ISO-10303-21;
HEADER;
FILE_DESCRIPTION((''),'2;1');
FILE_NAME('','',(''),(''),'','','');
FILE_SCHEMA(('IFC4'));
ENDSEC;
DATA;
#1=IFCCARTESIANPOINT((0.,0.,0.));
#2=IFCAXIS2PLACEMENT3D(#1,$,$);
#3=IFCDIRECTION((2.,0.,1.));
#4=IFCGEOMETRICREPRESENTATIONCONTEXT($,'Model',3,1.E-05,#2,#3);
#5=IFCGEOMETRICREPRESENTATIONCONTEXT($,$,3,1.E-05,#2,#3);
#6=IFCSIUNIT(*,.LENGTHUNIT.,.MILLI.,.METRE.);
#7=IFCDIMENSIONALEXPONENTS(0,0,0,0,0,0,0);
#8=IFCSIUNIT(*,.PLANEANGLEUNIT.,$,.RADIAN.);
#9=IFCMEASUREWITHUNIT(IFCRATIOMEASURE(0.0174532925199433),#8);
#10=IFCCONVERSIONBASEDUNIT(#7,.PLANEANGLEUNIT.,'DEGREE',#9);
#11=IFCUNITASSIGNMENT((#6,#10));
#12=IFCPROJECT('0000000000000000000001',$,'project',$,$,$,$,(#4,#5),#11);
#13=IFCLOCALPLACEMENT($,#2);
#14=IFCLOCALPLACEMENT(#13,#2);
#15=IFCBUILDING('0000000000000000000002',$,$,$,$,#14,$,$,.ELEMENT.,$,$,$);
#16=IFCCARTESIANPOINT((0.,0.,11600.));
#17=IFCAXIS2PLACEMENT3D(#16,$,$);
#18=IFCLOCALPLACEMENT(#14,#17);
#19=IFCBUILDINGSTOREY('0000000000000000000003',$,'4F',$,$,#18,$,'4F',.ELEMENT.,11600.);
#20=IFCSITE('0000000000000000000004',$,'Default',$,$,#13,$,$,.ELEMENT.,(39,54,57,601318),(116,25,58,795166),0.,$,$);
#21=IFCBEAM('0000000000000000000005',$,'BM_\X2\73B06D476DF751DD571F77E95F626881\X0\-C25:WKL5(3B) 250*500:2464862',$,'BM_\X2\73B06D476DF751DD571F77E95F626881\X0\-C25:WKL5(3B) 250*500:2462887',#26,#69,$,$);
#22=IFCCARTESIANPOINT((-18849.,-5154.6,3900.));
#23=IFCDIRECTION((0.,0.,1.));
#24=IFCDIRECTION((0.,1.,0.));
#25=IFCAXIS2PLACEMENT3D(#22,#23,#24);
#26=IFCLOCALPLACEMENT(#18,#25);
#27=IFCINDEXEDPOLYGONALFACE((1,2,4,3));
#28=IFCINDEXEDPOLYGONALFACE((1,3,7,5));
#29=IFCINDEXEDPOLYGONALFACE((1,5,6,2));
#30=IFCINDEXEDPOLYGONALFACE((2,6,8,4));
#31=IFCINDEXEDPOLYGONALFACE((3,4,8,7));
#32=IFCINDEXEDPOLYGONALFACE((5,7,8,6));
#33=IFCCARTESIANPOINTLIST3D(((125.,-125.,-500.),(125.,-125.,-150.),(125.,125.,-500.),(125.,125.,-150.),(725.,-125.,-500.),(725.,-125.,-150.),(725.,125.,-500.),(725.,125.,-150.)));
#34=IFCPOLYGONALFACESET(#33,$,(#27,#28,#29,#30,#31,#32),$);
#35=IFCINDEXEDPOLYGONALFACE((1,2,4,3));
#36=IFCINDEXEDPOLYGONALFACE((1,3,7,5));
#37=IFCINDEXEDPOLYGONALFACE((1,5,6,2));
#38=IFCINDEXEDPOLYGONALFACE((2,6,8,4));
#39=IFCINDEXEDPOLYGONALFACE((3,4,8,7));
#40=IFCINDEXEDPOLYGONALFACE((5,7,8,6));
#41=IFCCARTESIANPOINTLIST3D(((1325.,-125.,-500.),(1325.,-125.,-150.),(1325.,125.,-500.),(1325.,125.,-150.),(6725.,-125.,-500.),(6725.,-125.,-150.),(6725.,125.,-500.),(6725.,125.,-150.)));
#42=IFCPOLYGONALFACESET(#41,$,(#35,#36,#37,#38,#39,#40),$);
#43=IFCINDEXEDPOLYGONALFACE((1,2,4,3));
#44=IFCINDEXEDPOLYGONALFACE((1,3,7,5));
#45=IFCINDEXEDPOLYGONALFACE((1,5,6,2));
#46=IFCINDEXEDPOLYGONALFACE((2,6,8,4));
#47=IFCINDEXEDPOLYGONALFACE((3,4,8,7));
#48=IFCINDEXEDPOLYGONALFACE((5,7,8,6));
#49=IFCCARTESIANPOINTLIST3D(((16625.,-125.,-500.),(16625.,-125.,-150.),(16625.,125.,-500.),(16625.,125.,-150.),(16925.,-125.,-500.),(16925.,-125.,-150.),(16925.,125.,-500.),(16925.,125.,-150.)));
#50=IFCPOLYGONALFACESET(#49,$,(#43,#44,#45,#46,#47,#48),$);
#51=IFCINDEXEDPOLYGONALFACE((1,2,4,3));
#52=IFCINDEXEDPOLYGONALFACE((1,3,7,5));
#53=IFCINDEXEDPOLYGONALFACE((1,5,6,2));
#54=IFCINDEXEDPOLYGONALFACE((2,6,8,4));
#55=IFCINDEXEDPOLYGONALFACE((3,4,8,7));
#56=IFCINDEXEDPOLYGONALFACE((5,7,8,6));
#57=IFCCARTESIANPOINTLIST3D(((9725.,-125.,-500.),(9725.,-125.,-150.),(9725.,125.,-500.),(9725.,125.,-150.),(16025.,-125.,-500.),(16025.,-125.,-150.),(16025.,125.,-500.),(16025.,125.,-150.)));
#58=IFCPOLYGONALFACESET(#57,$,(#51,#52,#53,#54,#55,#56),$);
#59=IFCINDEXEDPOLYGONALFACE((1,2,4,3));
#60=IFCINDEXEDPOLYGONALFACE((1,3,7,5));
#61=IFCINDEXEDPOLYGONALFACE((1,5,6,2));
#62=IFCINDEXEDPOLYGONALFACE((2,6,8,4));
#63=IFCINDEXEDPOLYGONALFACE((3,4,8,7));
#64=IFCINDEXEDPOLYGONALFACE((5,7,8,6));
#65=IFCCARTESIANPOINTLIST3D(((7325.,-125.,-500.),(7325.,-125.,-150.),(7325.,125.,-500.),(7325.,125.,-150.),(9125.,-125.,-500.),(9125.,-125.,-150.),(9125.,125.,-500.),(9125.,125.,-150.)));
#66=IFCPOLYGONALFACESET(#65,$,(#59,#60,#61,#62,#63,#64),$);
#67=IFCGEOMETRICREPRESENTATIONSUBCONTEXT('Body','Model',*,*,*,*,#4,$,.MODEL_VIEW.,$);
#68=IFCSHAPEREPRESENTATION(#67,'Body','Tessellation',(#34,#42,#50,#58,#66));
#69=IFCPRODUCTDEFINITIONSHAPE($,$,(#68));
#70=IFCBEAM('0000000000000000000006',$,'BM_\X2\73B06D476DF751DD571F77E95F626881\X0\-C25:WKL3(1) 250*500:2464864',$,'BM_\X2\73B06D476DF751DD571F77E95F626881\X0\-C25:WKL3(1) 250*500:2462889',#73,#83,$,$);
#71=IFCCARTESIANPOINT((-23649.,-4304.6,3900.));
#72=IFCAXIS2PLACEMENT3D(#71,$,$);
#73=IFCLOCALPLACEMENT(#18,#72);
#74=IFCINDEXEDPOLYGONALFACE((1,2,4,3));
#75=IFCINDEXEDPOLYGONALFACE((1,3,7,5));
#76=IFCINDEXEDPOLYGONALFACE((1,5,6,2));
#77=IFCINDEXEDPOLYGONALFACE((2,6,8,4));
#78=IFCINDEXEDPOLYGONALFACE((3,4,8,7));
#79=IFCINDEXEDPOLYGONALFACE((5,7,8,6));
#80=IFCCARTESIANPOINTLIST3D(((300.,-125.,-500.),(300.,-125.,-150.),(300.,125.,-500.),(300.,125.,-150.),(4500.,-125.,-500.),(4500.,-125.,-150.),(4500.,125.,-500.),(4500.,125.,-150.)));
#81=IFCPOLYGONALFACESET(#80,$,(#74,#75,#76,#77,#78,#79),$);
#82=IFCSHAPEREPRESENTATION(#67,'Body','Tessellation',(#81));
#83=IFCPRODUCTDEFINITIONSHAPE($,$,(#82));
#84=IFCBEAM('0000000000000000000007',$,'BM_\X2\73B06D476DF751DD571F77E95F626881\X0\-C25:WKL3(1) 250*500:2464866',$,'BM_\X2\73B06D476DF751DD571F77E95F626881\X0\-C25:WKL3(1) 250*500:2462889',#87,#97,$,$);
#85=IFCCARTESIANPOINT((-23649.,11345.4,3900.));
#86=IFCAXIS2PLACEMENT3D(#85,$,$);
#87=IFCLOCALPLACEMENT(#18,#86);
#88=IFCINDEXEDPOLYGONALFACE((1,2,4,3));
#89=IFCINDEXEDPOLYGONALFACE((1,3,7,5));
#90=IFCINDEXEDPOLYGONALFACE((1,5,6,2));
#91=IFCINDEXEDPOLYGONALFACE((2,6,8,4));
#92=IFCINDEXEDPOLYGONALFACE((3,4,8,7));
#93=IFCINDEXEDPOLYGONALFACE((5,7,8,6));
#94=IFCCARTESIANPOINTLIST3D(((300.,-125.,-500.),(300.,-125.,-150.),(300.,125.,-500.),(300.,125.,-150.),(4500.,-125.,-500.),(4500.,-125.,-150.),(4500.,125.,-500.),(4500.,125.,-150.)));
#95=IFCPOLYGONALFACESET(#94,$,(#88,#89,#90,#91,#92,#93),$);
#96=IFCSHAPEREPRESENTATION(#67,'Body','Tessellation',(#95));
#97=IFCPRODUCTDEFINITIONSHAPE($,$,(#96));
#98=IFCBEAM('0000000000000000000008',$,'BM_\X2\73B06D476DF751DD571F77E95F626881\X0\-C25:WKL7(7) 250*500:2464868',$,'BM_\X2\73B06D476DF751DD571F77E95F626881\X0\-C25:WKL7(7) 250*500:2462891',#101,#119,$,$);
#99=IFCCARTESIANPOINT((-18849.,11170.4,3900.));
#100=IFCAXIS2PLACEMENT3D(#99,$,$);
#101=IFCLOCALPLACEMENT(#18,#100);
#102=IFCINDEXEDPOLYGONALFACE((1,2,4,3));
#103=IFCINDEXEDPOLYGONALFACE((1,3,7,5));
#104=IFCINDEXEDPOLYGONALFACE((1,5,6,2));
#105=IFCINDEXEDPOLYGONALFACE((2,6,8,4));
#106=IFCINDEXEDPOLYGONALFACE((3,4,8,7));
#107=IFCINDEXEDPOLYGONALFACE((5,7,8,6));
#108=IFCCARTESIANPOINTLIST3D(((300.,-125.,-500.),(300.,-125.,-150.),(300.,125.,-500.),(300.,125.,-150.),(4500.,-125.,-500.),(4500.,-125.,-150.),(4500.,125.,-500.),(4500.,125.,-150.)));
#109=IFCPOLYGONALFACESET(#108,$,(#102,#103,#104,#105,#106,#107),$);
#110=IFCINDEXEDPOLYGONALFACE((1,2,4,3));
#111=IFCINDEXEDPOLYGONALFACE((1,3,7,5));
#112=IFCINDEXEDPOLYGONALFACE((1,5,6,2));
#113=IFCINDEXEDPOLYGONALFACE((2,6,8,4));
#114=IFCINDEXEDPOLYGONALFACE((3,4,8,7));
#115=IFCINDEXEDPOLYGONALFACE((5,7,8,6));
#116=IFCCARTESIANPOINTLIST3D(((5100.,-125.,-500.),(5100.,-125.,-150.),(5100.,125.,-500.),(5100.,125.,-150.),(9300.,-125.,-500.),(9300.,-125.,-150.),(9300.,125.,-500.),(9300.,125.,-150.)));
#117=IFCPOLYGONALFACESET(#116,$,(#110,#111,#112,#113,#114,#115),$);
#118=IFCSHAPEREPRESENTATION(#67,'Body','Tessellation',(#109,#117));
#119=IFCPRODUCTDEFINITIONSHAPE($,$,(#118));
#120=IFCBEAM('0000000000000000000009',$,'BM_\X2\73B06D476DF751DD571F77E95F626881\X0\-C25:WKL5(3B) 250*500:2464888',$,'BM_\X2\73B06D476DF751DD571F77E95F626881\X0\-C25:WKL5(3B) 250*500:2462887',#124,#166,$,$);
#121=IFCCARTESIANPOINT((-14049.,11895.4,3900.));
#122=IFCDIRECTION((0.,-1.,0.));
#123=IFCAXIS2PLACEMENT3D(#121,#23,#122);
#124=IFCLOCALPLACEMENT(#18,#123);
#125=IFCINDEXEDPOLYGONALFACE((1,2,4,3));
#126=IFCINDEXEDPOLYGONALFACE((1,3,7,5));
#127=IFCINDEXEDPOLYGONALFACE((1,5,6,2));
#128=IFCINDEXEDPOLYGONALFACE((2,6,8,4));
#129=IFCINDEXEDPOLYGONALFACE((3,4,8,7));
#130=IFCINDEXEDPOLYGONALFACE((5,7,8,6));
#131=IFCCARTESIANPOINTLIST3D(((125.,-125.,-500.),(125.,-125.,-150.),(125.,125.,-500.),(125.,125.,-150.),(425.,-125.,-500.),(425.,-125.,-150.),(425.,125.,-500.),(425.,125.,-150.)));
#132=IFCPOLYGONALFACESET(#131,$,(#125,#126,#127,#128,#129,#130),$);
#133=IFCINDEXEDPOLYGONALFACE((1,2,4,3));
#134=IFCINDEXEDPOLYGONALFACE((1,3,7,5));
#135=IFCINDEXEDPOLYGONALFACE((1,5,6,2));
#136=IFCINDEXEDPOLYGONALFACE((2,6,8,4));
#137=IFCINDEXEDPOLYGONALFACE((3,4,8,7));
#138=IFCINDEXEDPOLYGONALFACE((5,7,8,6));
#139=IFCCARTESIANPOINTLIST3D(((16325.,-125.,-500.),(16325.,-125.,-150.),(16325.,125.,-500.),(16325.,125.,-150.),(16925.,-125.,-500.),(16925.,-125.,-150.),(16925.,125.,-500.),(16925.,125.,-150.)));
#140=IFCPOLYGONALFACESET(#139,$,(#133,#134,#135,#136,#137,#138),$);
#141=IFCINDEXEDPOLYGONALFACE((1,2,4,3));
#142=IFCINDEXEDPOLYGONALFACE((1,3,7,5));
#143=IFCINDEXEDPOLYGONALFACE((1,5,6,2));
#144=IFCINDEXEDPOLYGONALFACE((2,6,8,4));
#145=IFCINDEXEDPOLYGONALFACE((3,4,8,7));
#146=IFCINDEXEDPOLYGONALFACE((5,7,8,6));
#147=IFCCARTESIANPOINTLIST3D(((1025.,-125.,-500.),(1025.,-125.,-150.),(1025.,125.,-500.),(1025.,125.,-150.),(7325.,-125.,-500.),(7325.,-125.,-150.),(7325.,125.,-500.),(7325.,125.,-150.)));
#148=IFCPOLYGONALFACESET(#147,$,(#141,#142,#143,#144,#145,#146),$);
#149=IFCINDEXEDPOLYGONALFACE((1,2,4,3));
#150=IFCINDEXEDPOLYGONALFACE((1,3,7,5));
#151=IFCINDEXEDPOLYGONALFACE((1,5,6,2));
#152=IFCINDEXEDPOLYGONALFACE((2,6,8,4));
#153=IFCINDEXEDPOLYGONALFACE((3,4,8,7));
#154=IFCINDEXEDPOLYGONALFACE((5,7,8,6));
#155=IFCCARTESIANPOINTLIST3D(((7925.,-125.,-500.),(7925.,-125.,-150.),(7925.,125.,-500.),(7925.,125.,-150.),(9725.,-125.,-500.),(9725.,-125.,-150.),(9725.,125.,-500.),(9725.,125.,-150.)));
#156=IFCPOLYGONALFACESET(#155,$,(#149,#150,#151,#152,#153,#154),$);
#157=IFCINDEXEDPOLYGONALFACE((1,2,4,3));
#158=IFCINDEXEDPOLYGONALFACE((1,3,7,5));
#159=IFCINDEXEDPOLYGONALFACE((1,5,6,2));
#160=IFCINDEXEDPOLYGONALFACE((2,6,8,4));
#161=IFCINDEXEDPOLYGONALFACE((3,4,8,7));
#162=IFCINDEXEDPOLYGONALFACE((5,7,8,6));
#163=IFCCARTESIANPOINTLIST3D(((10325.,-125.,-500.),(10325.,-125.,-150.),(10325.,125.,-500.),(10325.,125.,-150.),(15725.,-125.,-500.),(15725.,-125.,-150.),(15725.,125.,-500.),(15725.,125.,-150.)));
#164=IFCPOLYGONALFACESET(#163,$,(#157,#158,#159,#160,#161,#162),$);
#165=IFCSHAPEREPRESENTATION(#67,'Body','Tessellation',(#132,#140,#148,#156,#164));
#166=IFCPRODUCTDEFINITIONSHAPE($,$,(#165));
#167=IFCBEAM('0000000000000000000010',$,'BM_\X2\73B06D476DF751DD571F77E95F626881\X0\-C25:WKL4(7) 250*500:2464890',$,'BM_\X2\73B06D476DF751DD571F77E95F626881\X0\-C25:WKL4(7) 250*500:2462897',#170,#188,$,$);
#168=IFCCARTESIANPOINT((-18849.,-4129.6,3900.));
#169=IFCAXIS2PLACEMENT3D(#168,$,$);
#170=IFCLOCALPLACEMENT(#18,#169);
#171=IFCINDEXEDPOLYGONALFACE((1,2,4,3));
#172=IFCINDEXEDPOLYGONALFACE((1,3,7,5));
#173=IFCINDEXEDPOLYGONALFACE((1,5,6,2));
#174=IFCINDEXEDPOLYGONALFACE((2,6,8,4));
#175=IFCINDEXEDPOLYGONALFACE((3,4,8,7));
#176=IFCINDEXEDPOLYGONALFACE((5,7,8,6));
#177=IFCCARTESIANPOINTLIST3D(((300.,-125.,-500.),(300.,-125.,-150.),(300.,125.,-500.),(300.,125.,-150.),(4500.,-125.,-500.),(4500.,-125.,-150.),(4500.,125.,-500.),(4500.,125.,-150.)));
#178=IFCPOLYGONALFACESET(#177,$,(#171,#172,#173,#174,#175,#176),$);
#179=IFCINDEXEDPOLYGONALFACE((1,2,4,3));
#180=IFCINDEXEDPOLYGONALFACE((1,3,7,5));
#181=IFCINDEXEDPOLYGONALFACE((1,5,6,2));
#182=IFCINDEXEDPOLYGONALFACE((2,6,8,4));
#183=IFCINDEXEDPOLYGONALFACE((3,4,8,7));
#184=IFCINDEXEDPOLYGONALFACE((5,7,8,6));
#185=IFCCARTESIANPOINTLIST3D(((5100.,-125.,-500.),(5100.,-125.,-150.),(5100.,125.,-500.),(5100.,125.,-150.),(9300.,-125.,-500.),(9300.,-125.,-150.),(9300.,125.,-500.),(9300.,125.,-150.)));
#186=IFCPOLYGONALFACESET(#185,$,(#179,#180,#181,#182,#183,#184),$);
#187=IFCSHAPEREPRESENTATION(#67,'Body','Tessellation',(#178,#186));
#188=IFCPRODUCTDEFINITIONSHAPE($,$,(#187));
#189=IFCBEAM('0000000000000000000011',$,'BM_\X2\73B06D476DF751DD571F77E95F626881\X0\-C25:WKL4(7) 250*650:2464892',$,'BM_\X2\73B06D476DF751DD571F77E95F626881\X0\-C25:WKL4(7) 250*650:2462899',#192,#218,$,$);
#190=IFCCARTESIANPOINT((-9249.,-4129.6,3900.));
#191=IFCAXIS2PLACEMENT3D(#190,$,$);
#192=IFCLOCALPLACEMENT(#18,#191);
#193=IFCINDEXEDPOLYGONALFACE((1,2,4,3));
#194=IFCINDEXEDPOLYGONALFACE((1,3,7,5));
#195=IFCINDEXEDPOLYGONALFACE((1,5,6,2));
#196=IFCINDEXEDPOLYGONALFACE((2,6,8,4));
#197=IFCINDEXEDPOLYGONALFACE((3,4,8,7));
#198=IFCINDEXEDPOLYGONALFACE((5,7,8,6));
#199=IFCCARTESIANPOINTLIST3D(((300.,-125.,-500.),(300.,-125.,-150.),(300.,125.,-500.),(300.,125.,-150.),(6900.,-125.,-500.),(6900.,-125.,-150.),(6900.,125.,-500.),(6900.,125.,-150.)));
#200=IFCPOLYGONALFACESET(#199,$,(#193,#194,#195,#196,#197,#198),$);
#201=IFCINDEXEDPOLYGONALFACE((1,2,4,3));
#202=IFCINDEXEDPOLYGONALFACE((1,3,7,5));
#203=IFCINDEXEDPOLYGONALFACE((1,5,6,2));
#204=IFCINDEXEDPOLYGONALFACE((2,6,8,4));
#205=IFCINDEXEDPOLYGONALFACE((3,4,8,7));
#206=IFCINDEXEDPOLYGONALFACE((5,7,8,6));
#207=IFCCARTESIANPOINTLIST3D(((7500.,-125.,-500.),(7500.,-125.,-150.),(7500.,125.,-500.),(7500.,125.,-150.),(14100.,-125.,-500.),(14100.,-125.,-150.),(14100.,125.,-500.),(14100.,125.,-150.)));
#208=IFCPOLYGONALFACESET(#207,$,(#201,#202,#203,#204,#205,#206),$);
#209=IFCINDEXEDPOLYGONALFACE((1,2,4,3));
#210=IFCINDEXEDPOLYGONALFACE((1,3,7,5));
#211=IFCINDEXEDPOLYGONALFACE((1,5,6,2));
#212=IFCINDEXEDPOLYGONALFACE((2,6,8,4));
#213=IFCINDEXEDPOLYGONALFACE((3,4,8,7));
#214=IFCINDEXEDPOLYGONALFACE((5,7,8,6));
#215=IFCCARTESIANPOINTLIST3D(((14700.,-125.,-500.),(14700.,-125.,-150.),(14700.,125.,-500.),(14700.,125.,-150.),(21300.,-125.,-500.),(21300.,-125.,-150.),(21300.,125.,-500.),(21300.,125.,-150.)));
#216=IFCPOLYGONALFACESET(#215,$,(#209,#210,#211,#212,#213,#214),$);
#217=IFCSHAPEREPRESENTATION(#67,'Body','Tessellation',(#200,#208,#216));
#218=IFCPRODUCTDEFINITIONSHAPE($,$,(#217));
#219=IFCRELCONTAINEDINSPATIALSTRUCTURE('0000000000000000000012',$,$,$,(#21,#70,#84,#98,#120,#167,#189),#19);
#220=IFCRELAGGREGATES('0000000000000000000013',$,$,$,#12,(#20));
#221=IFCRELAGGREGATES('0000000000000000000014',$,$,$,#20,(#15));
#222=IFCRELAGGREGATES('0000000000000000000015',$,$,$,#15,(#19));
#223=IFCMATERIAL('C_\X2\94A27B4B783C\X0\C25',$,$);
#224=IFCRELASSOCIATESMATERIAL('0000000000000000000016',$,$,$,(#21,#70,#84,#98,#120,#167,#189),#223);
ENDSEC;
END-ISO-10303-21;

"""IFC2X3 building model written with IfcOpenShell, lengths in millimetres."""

from ifc_helpers import new_model, entity, si_unit, converted_unit, direction, frame, frame_2d, origin, origin_2d_with_axis, place, context, subcontext, project, spatial, rectangle, extrude, material, element, save


model = new_model("IFC2X3")

# Units and contexts
model_context = context("Model", 3, precision=1e-05, world=origin(), true_north=direction((2.0, 0.0, 1.0)))
context_of_model = context(None, 3, precision=1e-05, world=origin(), true_north=direction((2.0, 0.0, 1.0)))
body_context = subcontext(model_context, "Body", "Model", "MODEL_VIEW")
ifc_project = project(units=[si_unit("LENGTHUNIT", "METRE", prefix="MILLI"), converted_unit("PLANEANGLEUNIT", "DEGREE", entity("IfcRatioMeasure", 0.0174532925199433), si_unit("PLANEANGLEUNIT", "RADIAN"), dimensions=[0, 0, 0, 0, 0, 0, 0])], contexts=[model_context, context_of_model])

# Site, building, storey
site_placement = place(None, origin())
site = spatial("IfcSite", under=ifc_project, at=site_placement, Name="Default", CompositionType="ELEMENT", RefLatitude=(39, 54, 57, 601318), RefLongitude=(116, 25, 58, 795166), RefElevation=0.0)
building_placement = place(site_placement, origin())
building = spatial("IfcBuilding", under=site, at=building_placement, CompositionType="ELEMENT")
storey_placement = place(building_placement, frame((0.0, 0.0, 11600.0)))
storey = spatial("IfcBuildingStorey", under=building, at=storey_placement, Name="4F", LongName="4F", CompositionType="ELEMENT", Elevation=11600.0)

# Beams
ifc_material = material(Name="C_钢筋砼C25")
beam_1_placement = place(storey_placement, frame((-18849.0, -5154.6, 3900.0), z_axis=(0.0, 0.0, 1.0), x_axis=(0.0, 1.0, 0.0)))
element("IfcBeam", 1, at=beam_1_placement, inside=storey, material=ifc_material, Name="BM_现浇混凝土矩形梁-C25:WKL5(3B) 250*500:2464862", ObjectType="BM_现浇混凝土矩形梁-C25:WKL5(3B) 250*500:2462887", context=body_context, shape_type="SweptSolid", body=[
    extrude(rectangle(XDim=350.0, YDim=250.0, at=origin_2d_with_axis()), frame((125.0, 0.0, -325.0), z_axis=(1.0, 0.0, 0.0), x_axis=(0.0, 0.0, 1.0)), (0.0, 0.0, 1.0), 600.0),
    extrude(rectangle(XDim=350.0, YDim=250.0, at=frame_2d((0.0, 0.0), x_axis=(1.0, 0.0))), frame((1325.0, 0.0, -325.0), z_axis=(1.0, 0.0, 0.0), x_axis=(0.0, 0.0, 1.0)), (0.0, 0.0, 1.0), 5400.0),
    extrude(rectangle(XDim=350.0, YDim=250.0, at=origin_2d_with_axis()), frame((16625.0, 0.0, -325.0), z_axis=(1.0, 0.0, 0.0), x_axis=(0.0, 0.0, 1.0)), (0.0, 0.0, 1.0), 300.0),
    extrude(rectangle(XDim=350.0, YDim=250.0, at=origin_2d_with_axis()), frame((9725.0, 0.0, -325.0), z_axis=(1.0, 0.0, 0.0), x_axis=(0.0, 0.0, 1.0)), (0.0, 0.0, 1.0), 6300.0),
    extrude(rectangle(XDim=350.0, YDim=250.0, at=frame_2d((0.0, 0.0), x_axis=(1.0, 0.0))), frame((7325.0, 0.0, -325.0), z_axis=(1.0, 0.0, 0.0), x_axis=(0.0, 0.0, 1.0)), (0.0, 0.0, 1.0), 1800.0),
])
beam_2_placement = place(storey_placement, frame((-23649.0, -4304.6, 3900.0)))
element("IfcBeam", 2, at=beam_2_placement, inside=storey, material=ifc_material, Name="BM_现浇混凝土矩形梁-C25:WKL3(1) 250*500:2464864", ObjectType="BM_现浇混凝土矩形梁-C25:WKL3(1) 250*500:2462889", context=body_context, shape_type="SweptSolid", body=[
    extrude(rectangle(XDim=350.0, YDim=250.0, at=frame_2d((0.0, 0.0), x_axis=(1.0, 0.0))), frame((300.0, 0.0, -325.0), z_axis=(1.0, 0.0, 0.0), x_axis=(0.0, 0.0, -1.0)), (0.0, 0.0, 1.0), 4200.0),
])
beam_3_placement = place(storey_placement, frame((-23649.0, 11345.4, 3900.0)))
element("IfcBeam", 3, at=beam_3_placement, inside=storey, material=ifc_material, Name="BM_现浇混凝土矩形梁-C25:WKL3(1) 250*500:2464866", ObjectType="BM_现浇混凝土矩形梁-C25:WKL3(1) 250*500:2462889", context=body_context, shape_type="SweptSolid", body=[
    extrude(rectangle(XDim=350.0, YDim=250.0, at=frame_2d((0.0, 0.0), x_axis=(1.0, 0.0))), frame((300.0, 0.0, -325.0), z_axis=(1.0, 0.0, 0.0), x_axis=(0.0, 0.0, -1.0)), (0.0, 0.0, 1.0), 4200.0),
])
beam_4_placement = place(storey_placement, frame((-18849.0, 11170.4, 3900.0)))
element("IfcBeam", 4, at=beam_4_placement, inside=storey, material=ifc_material, Name="BM_现浇混凝土矩形梁-C25:WKL7(7) 250*500:2464868", ObjectType="BM_现浇混凝土矩形梁-C25:WKL7(7) 250*500:2462891", context=body_context, shape_type="SweptSolid", body=[
    extrude(rectangle(XDim=350.0, YDim=250.0, at=origin_2d_with_axis()), frame((300.0, 0.0, -325.0), z_axis=(1.0, 0.0, 0.0), x_axis=(0.0, 0.0, 1.0)), (0.0, 0.0, 1.0), 4200.0),
    extrude(rectangle(XDim=350.0, YDim=250.0, at=origin_2d_with_axis()), frame((5100.0, 0.0, -325.0), z_axis=(1.0, 0.0, 0.0), x_axis=(0.0, 0.0, 1.0)), (0.0, 0.0, 1.0), 4200.0),
])
beam_5_placement = place(storey_placement, frame((-14049.0, 11895.4, 3900.0), z_axis=(0.0, 0.0, 1.0), x_axis=(0.0, -1.0, 0.0)))
element("IfcBeam", 5, at=beam_5_placement, inside=storey, material=ifc_material, Name="BM_现浇混凝土矩形梁-C25:WKL5(3B) 250*500:2464888", ObjectType="BM_现浇混凝土矩形梁-C25:WKL5(3B) 250*500:2462887", context=body_context, shape_type="SweptSolid", body=[
    extrude(rectangle(XDim=350.0, YDim=250.0, at=frame_2d((0.0, 0.0), x_axis=(1.0, 0.0))), frame((125.0, 0.0, -325.0), z_axis=(1.0, 0.0, 0.0), x_axis=(0.0, 0.0, 1.0)), (0.0, 0.0, 1.0), 300.0),
    extrude(rectangle(XDim=350.0, YDim=250.0, at=frame_2d((0.0, 0.0), x_axis=(1.0, 0.0))), frame((16325.0, 0.0, -325.0), z_axis=(1.0, 0.0, 0.0), x_axis=(0.0, 0.0, 1.0)), (0.0, 0.0, 1.0), 600.0),
    extrude(rectangle(XDim=350.0, YDim=250.0, at=origin_2d_with_axis()), frame((1025.0, 0.0, -325.0), z_axis=(1.0, 0.0, 0.0), x_axis=(0.0, 0.0, 1.0)), (0.0, 0.0, 1.0), 6300.0),
    extrude(rectangle(XDim=350.0, YDim=250.0, at=origin_2d_with_axis()), frame((7925.0, 0.0, -325.0), z_axis=(1.0, 0.0, 0.0), x_axis=(0.0, 0.0, 1.0)), (0.0, 0.0, 1.0), 1800.0),
    extrude(rectangle(XDim=350.0, YDim=250.0, at=frame_2d((0.0, 0.0), x_axis=(1.0, 0.0))), frame((10325.0, 0.0, -325.0), z_axis=(1.0, 0.0, 0.0), x_axis=(0.0, 0.0, 1.0)), (0.0, 0.0, 1.0), 5400.0),
])
beam_6_placement = place(storey_placement, frame((-18849.0, -4129.6, 3900.0)))
element("IfcBeam", 6, at=beam_6_placement, inside=storey, material=ifc_material, Name="BM_现浇混凝土矩形梁-C25:WKL4(7) 250*500:2464890", ObjectType="BM_现浇混凝土矩形梁-C25:WKL4(7) 250*500:2462897", context=body_context, shape_type="SweptSolid", body=[
    extrude(rectangle(XDim=350.0, YDim=250.0, at=frame_2d((0.0, 0.0), x_axis=(1.0, 0.0))), frame((300.0, 0.0, -325.0), z_axis=(1.0, 0.0, 0.0), x_axis=(0.0, 0.0, 1.0)), (0.0, 0.0, 1.0), 4200.0),
    extrude(rectangle(XDim=350.0, YDim=250.0, at=frame_2d((0.0, 0.0), x_axis=(1.0, 0.0))), frame((5100.0, 0.0, -325.0), z_axis=(1.0, 0.0, 0.0), x_axis=(0.0, 0.0, 1.0)), (0.0, 0.0, 1.0), 4200.0),
])
beam_7_placement = place(storey_placement, frame((-9249.0, -4129.6, 3900.0)))
element("IfcBeam", 7, at=beam_7_placement, inside=storey, material=ifc_material, Name="BM_现浇混凝土矩形梁-C25:WKL4(7) 250*650:2464892", ObjectType="BM_现浇混凝土矩形梁-C25:WKL4(7) 250*650:2462899", context=body_context, shape_type="SweptSolid", body=[
    extrude(rectangle(XDim=350.0, YDim=250.0, at=frame_2d((0.0, 0.0), x_axis=(1.0, 0.0))), frame((300.0, 0.0, -325.0), z_axis=(1.0, 0.0, 0.0), x_axis=(0.0, 0.0, 1.0)), (0.0, 0.0, 1.0), 6600.0),
    extrude(rectangle(XDim=350.0, YDim=250.0, at=frame_2d((0.0, 0.0), x_axis=(1.0, 0.0))), frame((7500.0, 0.0, -325.0), z_axis=(1.0, 0.0, 0.0), x_axis=(0.0, 0.0, 1.0)), (0.0, 0.0, 1.0), 6600.0),
    extrude(rectangle(XDim=350.0, YDim=250.0, at=frame_2d((0.0, 0.0), x_axis=(1.0, 0.0))), frame((14700.0, 0.0, -325.0), z_axis=(1.0, 0.0, 0.0), x_axis=(0.0, 0.0, 1.0)), (0.0, 0.0, 1.0), 6600.0),
])

save(model, "model.ifc")
